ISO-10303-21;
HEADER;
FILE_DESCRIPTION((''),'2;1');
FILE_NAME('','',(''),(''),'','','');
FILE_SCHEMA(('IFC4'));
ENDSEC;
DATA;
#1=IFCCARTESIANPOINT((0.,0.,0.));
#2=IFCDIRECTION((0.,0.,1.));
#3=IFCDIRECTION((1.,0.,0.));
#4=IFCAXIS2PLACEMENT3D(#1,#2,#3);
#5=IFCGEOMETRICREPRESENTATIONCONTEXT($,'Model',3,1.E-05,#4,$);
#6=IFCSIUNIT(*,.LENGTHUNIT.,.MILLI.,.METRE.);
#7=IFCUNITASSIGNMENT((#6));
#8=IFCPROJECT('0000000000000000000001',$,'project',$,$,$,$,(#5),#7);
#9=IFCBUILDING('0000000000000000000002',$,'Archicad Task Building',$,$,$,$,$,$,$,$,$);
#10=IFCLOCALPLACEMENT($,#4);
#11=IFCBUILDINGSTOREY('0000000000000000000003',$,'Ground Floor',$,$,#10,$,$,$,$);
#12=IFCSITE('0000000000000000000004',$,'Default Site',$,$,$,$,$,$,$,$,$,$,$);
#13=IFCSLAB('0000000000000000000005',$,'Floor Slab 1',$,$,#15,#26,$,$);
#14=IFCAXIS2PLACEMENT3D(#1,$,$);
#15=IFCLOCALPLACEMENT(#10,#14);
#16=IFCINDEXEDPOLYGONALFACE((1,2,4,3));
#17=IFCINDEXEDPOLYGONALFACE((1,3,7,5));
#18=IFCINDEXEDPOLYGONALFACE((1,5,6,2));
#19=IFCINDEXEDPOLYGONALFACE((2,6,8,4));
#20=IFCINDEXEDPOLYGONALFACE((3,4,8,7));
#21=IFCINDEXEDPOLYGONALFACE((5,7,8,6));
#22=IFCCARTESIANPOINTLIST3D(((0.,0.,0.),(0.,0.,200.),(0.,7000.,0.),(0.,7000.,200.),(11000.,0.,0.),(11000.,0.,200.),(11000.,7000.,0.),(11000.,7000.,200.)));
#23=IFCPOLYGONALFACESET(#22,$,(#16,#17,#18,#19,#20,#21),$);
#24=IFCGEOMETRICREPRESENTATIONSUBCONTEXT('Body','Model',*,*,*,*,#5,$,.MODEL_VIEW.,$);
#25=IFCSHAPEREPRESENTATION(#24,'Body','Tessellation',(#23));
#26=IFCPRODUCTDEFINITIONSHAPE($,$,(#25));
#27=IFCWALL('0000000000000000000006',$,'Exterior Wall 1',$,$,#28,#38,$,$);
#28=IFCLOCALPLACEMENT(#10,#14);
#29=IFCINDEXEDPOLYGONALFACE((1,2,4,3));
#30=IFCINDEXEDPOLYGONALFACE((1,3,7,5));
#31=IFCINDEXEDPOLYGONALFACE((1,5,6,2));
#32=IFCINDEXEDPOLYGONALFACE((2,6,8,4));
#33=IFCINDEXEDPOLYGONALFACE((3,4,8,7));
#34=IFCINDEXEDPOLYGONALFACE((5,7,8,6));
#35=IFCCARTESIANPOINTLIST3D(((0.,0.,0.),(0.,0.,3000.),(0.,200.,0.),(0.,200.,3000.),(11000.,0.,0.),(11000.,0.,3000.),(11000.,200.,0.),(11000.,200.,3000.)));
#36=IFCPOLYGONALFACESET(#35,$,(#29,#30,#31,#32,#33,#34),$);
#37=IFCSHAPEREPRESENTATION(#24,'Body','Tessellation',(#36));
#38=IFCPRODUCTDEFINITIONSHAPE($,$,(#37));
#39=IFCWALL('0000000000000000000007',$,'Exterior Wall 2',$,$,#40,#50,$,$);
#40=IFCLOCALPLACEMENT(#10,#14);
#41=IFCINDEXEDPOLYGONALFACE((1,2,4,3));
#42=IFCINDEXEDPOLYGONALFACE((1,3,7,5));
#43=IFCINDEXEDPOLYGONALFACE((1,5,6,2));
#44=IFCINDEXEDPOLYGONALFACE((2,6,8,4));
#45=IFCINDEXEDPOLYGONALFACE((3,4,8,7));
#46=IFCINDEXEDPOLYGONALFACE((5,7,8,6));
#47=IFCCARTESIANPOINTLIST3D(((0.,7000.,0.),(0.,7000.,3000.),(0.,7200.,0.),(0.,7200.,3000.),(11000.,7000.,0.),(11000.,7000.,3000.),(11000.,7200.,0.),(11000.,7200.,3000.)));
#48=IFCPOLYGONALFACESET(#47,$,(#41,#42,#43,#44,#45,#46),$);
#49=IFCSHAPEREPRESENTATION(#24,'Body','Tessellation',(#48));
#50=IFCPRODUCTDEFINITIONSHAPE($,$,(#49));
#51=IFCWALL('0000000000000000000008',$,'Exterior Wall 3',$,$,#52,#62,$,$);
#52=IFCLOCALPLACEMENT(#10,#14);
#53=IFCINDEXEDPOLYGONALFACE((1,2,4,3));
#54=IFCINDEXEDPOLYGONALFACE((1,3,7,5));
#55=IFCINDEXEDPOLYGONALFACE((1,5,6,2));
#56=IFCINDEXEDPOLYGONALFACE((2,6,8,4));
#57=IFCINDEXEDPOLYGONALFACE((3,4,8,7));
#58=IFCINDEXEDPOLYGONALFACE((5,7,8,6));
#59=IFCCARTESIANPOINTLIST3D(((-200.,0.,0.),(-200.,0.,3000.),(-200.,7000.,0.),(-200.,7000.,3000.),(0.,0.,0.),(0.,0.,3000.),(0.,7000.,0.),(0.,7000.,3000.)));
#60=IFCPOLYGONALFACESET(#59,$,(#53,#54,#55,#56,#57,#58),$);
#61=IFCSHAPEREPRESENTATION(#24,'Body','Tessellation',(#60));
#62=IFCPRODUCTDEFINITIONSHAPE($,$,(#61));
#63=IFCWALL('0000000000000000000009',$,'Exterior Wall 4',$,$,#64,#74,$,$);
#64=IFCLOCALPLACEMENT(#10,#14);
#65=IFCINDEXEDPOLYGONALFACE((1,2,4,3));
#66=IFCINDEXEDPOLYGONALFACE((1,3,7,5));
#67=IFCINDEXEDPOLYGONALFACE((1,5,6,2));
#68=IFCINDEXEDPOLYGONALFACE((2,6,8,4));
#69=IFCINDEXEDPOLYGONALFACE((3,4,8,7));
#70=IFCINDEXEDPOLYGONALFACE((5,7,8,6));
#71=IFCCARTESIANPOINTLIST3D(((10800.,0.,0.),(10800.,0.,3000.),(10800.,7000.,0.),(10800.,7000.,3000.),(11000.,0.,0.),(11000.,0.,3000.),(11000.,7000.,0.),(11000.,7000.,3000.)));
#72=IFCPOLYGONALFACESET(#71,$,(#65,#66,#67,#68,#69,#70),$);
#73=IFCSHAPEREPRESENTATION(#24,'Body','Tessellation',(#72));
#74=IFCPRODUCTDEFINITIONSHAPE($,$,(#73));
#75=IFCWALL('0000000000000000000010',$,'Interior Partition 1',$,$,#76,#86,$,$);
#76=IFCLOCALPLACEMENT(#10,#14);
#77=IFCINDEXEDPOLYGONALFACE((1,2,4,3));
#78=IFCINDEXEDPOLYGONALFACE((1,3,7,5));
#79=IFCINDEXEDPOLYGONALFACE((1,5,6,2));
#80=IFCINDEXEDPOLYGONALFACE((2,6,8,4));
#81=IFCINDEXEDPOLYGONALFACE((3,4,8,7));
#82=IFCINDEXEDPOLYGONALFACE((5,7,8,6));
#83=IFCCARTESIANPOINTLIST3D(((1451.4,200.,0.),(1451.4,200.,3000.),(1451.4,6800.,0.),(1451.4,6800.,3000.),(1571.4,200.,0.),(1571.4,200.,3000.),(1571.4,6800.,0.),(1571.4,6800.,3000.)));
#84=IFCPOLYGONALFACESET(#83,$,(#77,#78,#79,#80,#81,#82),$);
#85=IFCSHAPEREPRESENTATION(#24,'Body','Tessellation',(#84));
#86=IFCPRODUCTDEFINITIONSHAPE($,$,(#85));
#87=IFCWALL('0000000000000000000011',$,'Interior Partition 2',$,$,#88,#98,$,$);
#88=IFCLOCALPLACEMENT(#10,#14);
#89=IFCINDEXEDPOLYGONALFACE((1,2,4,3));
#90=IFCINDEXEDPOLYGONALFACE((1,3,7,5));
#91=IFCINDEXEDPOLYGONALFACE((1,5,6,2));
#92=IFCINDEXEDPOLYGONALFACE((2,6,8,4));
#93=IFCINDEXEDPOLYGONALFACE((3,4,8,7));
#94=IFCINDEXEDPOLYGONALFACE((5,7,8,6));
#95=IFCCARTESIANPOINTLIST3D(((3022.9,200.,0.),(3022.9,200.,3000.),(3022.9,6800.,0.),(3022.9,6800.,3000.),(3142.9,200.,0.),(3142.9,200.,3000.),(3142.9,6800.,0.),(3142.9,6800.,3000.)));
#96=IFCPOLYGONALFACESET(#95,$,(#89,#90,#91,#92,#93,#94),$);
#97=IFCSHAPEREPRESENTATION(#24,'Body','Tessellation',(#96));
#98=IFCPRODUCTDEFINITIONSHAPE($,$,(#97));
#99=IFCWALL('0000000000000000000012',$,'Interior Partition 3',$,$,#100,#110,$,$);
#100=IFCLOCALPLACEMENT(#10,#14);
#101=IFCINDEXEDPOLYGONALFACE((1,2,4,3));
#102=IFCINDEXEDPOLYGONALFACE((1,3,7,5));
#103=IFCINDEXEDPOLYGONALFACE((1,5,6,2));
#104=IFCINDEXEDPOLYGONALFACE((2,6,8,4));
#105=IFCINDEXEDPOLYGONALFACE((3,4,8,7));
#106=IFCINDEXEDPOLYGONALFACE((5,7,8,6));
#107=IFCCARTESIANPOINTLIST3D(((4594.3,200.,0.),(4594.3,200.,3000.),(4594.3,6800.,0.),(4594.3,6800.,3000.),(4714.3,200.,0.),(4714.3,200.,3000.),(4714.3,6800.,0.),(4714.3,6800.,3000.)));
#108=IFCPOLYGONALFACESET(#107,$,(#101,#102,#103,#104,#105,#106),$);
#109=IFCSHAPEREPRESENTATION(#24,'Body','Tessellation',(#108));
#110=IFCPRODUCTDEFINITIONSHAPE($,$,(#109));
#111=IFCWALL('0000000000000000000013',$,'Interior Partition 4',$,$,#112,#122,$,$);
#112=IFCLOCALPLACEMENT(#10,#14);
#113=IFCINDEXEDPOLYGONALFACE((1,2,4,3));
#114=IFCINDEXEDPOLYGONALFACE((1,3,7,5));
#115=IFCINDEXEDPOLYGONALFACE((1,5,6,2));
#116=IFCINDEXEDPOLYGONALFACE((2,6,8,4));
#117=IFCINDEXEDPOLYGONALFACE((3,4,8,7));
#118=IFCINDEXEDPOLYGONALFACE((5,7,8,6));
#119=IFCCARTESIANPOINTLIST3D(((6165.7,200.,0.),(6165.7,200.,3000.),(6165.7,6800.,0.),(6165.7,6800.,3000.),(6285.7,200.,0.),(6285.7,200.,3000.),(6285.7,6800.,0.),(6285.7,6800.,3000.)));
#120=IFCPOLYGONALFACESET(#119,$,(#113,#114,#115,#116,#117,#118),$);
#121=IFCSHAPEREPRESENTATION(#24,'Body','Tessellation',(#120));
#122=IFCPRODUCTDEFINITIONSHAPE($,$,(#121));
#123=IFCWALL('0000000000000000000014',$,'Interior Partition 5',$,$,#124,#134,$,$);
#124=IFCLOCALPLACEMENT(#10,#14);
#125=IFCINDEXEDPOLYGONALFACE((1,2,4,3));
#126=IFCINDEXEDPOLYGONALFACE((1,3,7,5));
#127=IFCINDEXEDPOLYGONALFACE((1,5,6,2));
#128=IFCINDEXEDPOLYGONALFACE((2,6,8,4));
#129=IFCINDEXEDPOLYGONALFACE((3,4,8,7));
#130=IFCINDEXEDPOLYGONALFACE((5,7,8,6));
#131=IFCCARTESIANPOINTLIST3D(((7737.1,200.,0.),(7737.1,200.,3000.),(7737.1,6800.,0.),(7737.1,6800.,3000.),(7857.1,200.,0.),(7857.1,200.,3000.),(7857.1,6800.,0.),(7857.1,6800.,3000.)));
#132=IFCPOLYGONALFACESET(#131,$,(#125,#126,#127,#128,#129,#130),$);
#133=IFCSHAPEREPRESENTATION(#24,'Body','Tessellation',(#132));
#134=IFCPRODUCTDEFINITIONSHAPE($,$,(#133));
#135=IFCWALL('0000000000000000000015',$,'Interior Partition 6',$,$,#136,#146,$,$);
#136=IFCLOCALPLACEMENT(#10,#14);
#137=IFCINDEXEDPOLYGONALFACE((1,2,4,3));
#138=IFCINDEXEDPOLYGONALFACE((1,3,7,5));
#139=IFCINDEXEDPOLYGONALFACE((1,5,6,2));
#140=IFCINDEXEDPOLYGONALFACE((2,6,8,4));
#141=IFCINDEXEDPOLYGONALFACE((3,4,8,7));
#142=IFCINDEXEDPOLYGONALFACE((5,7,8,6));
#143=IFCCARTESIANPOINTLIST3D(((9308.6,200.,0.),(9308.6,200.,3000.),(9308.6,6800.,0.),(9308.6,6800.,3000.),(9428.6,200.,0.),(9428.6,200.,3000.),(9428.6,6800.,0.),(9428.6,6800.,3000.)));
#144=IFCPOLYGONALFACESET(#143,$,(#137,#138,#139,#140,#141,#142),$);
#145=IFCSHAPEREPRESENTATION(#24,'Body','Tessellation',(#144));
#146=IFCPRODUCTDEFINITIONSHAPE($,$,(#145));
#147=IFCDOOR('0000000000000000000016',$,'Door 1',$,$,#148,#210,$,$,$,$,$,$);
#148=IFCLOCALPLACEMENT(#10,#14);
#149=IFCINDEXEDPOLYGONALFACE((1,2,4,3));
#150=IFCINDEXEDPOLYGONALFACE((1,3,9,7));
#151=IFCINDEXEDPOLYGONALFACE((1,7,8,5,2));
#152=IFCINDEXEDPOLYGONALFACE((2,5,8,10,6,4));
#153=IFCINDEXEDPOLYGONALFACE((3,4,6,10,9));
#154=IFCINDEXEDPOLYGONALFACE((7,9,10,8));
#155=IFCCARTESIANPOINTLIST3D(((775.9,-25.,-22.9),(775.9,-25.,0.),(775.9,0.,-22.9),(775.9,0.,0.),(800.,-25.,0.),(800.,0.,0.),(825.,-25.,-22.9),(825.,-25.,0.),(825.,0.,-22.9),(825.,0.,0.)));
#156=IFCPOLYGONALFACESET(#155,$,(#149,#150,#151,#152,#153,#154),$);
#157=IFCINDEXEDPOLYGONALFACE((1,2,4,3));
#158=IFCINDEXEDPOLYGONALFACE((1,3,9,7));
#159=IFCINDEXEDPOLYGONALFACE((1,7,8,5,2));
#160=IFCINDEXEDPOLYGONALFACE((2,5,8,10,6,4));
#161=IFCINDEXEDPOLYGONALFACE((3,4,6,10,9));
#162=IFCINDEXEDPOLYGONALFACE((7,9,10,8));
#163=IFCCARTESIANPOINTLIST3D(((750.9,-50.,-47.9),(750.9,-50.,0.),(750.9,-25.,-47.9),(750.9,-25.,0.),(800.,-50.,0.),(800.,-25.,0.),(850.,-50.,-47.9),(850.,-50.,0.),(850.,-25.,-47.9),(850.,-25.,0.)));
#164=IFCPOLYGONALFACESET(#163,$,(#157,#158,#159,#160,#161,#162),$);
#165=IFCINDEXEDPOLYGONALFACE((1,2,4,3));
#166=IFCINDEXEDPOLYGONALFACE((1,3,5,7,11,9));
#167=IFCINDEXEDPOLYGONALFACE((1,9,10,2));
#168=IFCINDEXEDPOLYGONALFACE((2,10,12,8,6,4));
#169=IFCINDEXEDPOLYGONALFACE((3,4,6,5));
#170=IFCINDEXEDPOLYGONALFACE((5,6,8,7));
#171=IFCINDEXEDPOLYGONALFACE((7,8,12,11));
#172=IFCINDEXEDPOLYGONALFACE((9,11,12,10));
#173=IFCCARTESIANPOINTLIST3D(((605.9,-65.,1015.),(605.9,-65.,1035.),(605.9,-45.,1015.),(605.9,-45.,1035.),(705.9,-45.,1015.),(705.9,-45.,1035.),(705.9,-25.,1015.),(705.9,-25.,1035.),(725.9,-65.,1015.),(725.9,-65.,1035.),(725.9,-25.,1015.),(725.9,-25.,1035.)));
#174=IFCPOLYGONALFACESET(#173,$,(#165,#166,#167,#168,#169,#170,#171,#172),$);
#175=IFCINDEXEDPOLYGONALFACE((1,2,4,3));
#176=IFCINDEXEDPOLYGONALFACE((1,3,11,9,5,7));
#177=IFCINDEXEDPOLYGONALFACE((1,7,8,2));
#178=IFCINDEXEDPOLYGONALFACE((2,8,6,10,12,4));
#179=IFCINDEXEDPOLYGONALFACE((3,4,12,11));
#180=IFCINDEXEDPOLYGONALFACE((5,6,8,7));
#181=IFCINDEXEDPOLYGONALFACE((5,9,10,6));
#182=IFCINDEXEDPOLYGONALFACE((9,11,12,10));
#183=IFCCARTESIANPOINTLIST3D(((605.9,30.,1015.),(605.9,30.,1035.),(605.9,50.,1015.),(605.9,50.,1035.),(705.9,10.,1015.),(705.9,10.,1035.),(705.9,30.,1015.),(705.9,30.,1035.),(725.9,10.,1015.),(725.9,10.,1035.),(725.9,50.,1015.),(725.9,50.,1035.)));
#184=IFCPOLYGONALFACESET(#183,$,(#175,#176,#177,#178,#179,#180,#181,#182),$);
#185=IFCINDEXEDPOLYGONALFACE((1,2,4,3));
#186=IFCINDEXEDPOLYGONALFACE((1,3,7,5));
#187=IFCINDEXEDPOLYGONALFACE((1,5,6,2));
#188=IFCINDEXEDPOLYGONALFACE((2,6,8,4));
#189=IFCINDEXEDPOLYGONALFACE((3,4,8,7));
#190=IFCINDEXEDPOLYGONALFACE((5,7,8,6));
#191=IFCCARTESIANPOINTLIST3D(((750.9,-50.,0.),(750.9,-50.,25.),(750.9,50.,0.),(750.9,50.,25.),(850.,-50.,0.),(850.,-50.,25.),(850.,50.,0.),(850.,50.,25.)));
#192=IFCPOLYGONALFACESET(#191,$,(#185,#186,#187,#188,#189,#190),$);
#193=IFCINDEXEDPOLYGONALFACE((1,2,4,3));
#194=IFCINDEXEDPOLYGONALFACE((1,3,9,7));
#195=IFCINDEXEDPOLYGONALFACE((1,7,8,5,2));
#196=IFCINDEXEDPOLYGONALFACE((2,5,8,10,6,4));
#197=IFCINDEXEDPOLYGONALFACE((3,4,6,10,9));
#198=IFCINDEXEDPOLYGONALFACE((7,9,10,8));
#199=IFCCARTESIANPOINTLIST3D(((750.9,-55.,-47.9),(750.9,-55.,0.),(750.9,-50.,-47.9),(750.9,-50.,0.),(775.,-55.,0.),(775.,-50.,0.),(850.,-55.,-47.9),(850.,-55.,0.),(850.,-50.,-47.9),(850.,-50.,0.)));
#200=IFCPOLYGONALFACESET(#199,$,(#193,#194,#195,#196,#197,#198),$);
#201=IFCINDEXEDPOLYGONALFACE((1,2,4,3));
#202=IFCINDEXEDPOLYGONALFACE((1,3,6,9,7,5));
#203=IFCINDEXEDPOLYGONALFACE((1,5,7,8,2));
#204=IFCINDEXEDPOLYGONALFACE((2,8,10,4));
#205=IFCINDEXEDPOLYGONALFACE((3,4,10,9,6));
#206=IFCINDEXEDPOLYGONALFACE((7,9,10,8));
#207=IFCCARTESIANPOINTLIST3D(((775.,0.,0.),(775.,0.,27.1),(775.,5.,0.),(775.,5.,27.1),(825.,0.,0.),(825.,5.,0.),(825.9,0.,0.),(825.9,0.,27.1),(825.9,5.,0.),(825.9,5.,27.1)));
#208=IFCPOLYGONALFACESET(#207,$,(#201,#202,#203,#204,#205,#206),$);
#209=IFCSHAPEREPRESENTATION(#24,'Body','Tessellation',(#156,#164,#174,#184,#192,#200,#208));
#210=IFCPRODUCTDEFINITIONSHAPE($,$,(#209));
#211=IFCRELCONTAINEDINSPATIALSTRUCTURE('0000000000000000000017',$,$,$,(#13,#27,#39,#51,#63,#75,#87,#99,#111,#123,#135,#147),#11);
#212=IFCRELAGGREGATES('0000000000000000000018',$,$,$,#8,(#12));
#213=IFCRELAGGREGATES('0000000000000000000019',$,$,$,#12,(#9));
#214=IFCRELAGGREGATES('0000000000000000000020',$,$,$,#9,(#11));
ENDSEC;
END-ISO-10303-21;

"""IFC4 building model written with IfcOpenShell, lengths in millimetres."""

from ifc_helpers import new_model, si_unit, frame, origin_with_axes, place, context, subcontext, project, spatial, line, indexed_curve, outline, extrude, element, save


model = new_model("IFC4")

# Units and contexts
model_context = context("Model", 3, precision=1e-05, world=origin_with_axes())
body_context = subcontext(model_context, "Body", "Model", "MODEL_VIEW")
ifc_project = project(units=[si_unit("LENGTHUNIT", "METRE", prefix="MILLI")], contexts=[model_context])

# Site, building, storey
site = spatial("IfcSite", under=ifc_project, Name="Default Site")
building = spatial("IfcBuilding", under=site, Name="Archicad Task Building")
storey_placement = place(None, origin_with_axes())
storey = spatial("IfcBuildingStorey", under=building, at=storey_placement, Name="Ground Floor")

# Slab
slab_placement = place(storey_placement, origin_with_axes())
element("IfcSlab", 1, at=slab_placement, inside=storey, Name="Floor Slab 1", context=body_context, shape_type="SweptSolid", body=[
    extrude(outline(indexed_curve([(0.0, 0.0), (11000.0, 0.0), (11000.0, 7000.0), (0.0, 7000.0), (0.0, 0.0)])), None, (0.0, 0.0, 1.0), 200.0),
])

# Walls
for number, where, z_axis, x_axis, name in (
    (2, (0.0, 0.0, 0.0), (0.0, 0.0, 1.0), (1.0, 0.0, 0.0), "Exterior Wall 1"),
    (3, (0.0, 7000.0, 0.0), (0.0, 0.0, 1.0), (1.0, 0.0, 0.0), "Exterior Wall 2"),
):
    element("IfcWall", number, at=place(storey_placement, frame(where, z_axis=z_axis, x_axis=x_axis)), inside=storey, Name=name, context=body_context, shape_type="SweptSolid", body=[
        extrude(outline(indexed_curve([(0.0, 0.0), (0.0, 200.0), (11000.0, 200.0), (11000.0, 0.0), (0.0, 0.0)], self_intersect=False)), origin_with_axes(), (0.0, 0.0, 1.0), 3000.0),
    ])
for number, where, z_axis, x_axis, name in (
    (4, (0.0, 0.0, 0.0), (0.0, 0.0, 1.0), (0.0, 1.0, 0.0), "Exterior Wall 3"),
    (5, (11000.0, 0.0, 0.0), (0.0, 0.0, 1.0), (0.0, 1.0, 0.0), "Exterior Wall 4"),
):
    element("IfcWall", number, at=place(storey_placement, frame(where, z_axis=z_axis, x_axis=x_axis)), inside=storey, Name=name, context=body_context, shape_type="SweptSolid", body=[
        extrude(outline(indexed_curve([(0.0, 0.0), (0.0, 200.0), (7000.0, 200.0), (7000.0, 0.0), (0.0, 0.0)], self_intersect=False)), origin_with_axes(), (0.0, 0.0, 1.0), 3000.0),
    ])
for number, where, z_axis, x_axis, name in (
    (6, (1571.4, 200.0, 0.0), (0.0, 0.0, 1.0), (0.0, 1.0, 0.0), "Interior Partition 1"),
    (7, (3142.9, 200.0, 0.0), (0.0, 0.0, 1.0), (0.0, 1.0, 0.0), "Interior Partition 2"),
    (8, (4714.3, 200.0, 0.0), (0.0, 0.0, 1.0), (0.0, 1.0, 0.0), "Interior Partition 3"),
    (9, (6285.7, 200.0, 0.0), (0.0, 0.0, 1.0), (0.0, 1.0, 0.0), "Interior Partition 4"),
    (10, (7857.1, 200.0, 0.0), (0.0, 0.0, 1.0), (0.0, 1.0, 0.0), "Interior Partition 5"),
    (11, (9428.6, 200.0, 0.0), (0.0, 0.0, 1.0), (0.0, 1.0, 0.0), "Interior Partition 6"),
):
    element("IfcWall", number, at=place(storey_placement, frame(where, z_axis=z_axis, x_axis=x_axis)), inside=storey, Name=name, context=body_context, shape_type="SweptSolid", body=[
        extrude(outline(indexed_curve([(0.0, 0.0), (0.0, 120.0), (6600.0, 120.0), (6600.0, 0.0), (0.0, 0.0)], self_intersect=False)), origin_with_axes(), (0.0, 0.0, 1.0), 3000.0),
    ])

# Door
door_1_placement = place(storey_placement, frame((800.0, -50.0, 0.0), z_axis=(0.0, 0.0, 1.0), x_axis=(1.0, 0.0, 0.0)))
element("IfcDoor", 12, at=door_1_placement, inside=storey, Name="Door 1", context=body_context, shape_type="SweptSolid", body=[
    extrude(outline(indexed_curve([(0.0, 0.0), (0.0, 2.1), (0.9, 2.1), (0.9, 0.0), (-24.1, 0.0), (-24.1, -22.9), (25.0, -22.9), (25.0, 0.0)], segments=[line(1, 2, 3, 4, 5, 6, 7, 8, 1)])), frame((0.0, 25.0, 0.0), z_axis=(0.0, -1.0, 0.0), x_axis=(1.0, 0.0, 0.0)), (0.0, 0.0, -1.0), 25.0),
    extrude(outline(indexed_curve([(0.0, 0.0), (0.0, 2.1), (0.9, 2.1), (0.9, 0.0), (-49.1, 0.0), (-49.1, -47.9), (50.0, -47.9), (50.0, 0.0)], segments=[line(1, 2, 3, 4, 5, 6, 7, 8, 1)])), frame((0.0, 0.0, 0.0), z_axis=(0.0, -1.0, 0.0), x_axis=(1.0, 0.0, 0.0)), (0.0, 0.0, -1.0), 25.0),
    extrude(outline(indexed_curve([(0.0, 0.0), (-49.1, 0.0), (-49.1, 35.0), (0.0, 35.0)], segments=[line(1, 2, 3, 4, 1)])), frame((25.0, 25.0, 25.0), z_axis=(0.0, 0.0, 1.0), x_axis=(1.0, 0.0, 0.0)), (0.0, 0.0, 1.0), -47.9),
    extrude(outline(indexed_curve([(0.0, 0.0), (0.0, -40.0), (-120.0, -40.0), (-120.0, -20.0), (-20.0, -20.0), (-20.0, 0.0)], segments=[line(1, 2, 3, 4, 5, 6, 1)])), frame((-74.1, 25.0, 1015.0), z_axis=(0.0, 0.0, 1.0), x_axis=(1.0, 0.0, 0.0)), (0.0, 0.0, 1.0), 20.0),
    extrude(outline(indexed_curve([(0.0, 0.0), (0.0, 40.0), (-120.0, 40.0), (-120.0, 20.0), (-20.0, 20.0), (-20.0, 0.0)], segments=[line(1, 2, 3, 4, 5, 6, 1)])), frame((-74.1, 60.0, 1015.0), z_axis=(0.0, 0.0, 1.0), x_axis=(1.0, 0.0, 0.0)), (0.0, 0.0, 1.0), 20.0),
    extrude(outline(indexed_curve([(0.0, 0.0), (-99.1, 0.0), (-99.1, 100.0), (0.0, 100.0)], segments=[line(1, 2, 3, 4, 1)])), frame((50.0, 0.0, 0.0), z_axis=(0.0, 0.0, 1.0), x_axis=(1.0, 0.0, 0.0)), (0.0, 0.0, 1.0), 25.0),
    extrude(outline(indexed_curve([(0.0, 0.0), (0.0, 27.1), (50.9, 27.1), (50.9, 0.0), (-24.1, 0.0), (-24.1, -47.9), (75.0, -47.9), (75.0, 0.0)], segments=[line(1, 2, 3, 4, 5, 6, 7, 8, 1)])), frame((-25.0, -5.0, 0.0), z_axis=(0.0, -1.0, 0.0), x_axis=(1.0, 0.0, 0.0)), (0.0, 0.0, -1.0), 5.0),
    extrude(outline(indexed_curve([(0.0, 0.0), (0.0, 27.1), (50.9, 27.1), (50.9, 0.0), (0.9, 0.0), (0.9, -22.9), (50.0, -22.9), (50.0, 0.0)], segments=[line(1, 2, 3, 4, 5, 6, 7, 8, 1)])), frame((-25.0, 50.0, 0.0), z_axis=(0.0, -1.0, 0.0), x_axis=(1.0, 0.0, 0.0)), (0.0, 0.0, -1.0), 5.0),
])

save(model, "model.ifc")
